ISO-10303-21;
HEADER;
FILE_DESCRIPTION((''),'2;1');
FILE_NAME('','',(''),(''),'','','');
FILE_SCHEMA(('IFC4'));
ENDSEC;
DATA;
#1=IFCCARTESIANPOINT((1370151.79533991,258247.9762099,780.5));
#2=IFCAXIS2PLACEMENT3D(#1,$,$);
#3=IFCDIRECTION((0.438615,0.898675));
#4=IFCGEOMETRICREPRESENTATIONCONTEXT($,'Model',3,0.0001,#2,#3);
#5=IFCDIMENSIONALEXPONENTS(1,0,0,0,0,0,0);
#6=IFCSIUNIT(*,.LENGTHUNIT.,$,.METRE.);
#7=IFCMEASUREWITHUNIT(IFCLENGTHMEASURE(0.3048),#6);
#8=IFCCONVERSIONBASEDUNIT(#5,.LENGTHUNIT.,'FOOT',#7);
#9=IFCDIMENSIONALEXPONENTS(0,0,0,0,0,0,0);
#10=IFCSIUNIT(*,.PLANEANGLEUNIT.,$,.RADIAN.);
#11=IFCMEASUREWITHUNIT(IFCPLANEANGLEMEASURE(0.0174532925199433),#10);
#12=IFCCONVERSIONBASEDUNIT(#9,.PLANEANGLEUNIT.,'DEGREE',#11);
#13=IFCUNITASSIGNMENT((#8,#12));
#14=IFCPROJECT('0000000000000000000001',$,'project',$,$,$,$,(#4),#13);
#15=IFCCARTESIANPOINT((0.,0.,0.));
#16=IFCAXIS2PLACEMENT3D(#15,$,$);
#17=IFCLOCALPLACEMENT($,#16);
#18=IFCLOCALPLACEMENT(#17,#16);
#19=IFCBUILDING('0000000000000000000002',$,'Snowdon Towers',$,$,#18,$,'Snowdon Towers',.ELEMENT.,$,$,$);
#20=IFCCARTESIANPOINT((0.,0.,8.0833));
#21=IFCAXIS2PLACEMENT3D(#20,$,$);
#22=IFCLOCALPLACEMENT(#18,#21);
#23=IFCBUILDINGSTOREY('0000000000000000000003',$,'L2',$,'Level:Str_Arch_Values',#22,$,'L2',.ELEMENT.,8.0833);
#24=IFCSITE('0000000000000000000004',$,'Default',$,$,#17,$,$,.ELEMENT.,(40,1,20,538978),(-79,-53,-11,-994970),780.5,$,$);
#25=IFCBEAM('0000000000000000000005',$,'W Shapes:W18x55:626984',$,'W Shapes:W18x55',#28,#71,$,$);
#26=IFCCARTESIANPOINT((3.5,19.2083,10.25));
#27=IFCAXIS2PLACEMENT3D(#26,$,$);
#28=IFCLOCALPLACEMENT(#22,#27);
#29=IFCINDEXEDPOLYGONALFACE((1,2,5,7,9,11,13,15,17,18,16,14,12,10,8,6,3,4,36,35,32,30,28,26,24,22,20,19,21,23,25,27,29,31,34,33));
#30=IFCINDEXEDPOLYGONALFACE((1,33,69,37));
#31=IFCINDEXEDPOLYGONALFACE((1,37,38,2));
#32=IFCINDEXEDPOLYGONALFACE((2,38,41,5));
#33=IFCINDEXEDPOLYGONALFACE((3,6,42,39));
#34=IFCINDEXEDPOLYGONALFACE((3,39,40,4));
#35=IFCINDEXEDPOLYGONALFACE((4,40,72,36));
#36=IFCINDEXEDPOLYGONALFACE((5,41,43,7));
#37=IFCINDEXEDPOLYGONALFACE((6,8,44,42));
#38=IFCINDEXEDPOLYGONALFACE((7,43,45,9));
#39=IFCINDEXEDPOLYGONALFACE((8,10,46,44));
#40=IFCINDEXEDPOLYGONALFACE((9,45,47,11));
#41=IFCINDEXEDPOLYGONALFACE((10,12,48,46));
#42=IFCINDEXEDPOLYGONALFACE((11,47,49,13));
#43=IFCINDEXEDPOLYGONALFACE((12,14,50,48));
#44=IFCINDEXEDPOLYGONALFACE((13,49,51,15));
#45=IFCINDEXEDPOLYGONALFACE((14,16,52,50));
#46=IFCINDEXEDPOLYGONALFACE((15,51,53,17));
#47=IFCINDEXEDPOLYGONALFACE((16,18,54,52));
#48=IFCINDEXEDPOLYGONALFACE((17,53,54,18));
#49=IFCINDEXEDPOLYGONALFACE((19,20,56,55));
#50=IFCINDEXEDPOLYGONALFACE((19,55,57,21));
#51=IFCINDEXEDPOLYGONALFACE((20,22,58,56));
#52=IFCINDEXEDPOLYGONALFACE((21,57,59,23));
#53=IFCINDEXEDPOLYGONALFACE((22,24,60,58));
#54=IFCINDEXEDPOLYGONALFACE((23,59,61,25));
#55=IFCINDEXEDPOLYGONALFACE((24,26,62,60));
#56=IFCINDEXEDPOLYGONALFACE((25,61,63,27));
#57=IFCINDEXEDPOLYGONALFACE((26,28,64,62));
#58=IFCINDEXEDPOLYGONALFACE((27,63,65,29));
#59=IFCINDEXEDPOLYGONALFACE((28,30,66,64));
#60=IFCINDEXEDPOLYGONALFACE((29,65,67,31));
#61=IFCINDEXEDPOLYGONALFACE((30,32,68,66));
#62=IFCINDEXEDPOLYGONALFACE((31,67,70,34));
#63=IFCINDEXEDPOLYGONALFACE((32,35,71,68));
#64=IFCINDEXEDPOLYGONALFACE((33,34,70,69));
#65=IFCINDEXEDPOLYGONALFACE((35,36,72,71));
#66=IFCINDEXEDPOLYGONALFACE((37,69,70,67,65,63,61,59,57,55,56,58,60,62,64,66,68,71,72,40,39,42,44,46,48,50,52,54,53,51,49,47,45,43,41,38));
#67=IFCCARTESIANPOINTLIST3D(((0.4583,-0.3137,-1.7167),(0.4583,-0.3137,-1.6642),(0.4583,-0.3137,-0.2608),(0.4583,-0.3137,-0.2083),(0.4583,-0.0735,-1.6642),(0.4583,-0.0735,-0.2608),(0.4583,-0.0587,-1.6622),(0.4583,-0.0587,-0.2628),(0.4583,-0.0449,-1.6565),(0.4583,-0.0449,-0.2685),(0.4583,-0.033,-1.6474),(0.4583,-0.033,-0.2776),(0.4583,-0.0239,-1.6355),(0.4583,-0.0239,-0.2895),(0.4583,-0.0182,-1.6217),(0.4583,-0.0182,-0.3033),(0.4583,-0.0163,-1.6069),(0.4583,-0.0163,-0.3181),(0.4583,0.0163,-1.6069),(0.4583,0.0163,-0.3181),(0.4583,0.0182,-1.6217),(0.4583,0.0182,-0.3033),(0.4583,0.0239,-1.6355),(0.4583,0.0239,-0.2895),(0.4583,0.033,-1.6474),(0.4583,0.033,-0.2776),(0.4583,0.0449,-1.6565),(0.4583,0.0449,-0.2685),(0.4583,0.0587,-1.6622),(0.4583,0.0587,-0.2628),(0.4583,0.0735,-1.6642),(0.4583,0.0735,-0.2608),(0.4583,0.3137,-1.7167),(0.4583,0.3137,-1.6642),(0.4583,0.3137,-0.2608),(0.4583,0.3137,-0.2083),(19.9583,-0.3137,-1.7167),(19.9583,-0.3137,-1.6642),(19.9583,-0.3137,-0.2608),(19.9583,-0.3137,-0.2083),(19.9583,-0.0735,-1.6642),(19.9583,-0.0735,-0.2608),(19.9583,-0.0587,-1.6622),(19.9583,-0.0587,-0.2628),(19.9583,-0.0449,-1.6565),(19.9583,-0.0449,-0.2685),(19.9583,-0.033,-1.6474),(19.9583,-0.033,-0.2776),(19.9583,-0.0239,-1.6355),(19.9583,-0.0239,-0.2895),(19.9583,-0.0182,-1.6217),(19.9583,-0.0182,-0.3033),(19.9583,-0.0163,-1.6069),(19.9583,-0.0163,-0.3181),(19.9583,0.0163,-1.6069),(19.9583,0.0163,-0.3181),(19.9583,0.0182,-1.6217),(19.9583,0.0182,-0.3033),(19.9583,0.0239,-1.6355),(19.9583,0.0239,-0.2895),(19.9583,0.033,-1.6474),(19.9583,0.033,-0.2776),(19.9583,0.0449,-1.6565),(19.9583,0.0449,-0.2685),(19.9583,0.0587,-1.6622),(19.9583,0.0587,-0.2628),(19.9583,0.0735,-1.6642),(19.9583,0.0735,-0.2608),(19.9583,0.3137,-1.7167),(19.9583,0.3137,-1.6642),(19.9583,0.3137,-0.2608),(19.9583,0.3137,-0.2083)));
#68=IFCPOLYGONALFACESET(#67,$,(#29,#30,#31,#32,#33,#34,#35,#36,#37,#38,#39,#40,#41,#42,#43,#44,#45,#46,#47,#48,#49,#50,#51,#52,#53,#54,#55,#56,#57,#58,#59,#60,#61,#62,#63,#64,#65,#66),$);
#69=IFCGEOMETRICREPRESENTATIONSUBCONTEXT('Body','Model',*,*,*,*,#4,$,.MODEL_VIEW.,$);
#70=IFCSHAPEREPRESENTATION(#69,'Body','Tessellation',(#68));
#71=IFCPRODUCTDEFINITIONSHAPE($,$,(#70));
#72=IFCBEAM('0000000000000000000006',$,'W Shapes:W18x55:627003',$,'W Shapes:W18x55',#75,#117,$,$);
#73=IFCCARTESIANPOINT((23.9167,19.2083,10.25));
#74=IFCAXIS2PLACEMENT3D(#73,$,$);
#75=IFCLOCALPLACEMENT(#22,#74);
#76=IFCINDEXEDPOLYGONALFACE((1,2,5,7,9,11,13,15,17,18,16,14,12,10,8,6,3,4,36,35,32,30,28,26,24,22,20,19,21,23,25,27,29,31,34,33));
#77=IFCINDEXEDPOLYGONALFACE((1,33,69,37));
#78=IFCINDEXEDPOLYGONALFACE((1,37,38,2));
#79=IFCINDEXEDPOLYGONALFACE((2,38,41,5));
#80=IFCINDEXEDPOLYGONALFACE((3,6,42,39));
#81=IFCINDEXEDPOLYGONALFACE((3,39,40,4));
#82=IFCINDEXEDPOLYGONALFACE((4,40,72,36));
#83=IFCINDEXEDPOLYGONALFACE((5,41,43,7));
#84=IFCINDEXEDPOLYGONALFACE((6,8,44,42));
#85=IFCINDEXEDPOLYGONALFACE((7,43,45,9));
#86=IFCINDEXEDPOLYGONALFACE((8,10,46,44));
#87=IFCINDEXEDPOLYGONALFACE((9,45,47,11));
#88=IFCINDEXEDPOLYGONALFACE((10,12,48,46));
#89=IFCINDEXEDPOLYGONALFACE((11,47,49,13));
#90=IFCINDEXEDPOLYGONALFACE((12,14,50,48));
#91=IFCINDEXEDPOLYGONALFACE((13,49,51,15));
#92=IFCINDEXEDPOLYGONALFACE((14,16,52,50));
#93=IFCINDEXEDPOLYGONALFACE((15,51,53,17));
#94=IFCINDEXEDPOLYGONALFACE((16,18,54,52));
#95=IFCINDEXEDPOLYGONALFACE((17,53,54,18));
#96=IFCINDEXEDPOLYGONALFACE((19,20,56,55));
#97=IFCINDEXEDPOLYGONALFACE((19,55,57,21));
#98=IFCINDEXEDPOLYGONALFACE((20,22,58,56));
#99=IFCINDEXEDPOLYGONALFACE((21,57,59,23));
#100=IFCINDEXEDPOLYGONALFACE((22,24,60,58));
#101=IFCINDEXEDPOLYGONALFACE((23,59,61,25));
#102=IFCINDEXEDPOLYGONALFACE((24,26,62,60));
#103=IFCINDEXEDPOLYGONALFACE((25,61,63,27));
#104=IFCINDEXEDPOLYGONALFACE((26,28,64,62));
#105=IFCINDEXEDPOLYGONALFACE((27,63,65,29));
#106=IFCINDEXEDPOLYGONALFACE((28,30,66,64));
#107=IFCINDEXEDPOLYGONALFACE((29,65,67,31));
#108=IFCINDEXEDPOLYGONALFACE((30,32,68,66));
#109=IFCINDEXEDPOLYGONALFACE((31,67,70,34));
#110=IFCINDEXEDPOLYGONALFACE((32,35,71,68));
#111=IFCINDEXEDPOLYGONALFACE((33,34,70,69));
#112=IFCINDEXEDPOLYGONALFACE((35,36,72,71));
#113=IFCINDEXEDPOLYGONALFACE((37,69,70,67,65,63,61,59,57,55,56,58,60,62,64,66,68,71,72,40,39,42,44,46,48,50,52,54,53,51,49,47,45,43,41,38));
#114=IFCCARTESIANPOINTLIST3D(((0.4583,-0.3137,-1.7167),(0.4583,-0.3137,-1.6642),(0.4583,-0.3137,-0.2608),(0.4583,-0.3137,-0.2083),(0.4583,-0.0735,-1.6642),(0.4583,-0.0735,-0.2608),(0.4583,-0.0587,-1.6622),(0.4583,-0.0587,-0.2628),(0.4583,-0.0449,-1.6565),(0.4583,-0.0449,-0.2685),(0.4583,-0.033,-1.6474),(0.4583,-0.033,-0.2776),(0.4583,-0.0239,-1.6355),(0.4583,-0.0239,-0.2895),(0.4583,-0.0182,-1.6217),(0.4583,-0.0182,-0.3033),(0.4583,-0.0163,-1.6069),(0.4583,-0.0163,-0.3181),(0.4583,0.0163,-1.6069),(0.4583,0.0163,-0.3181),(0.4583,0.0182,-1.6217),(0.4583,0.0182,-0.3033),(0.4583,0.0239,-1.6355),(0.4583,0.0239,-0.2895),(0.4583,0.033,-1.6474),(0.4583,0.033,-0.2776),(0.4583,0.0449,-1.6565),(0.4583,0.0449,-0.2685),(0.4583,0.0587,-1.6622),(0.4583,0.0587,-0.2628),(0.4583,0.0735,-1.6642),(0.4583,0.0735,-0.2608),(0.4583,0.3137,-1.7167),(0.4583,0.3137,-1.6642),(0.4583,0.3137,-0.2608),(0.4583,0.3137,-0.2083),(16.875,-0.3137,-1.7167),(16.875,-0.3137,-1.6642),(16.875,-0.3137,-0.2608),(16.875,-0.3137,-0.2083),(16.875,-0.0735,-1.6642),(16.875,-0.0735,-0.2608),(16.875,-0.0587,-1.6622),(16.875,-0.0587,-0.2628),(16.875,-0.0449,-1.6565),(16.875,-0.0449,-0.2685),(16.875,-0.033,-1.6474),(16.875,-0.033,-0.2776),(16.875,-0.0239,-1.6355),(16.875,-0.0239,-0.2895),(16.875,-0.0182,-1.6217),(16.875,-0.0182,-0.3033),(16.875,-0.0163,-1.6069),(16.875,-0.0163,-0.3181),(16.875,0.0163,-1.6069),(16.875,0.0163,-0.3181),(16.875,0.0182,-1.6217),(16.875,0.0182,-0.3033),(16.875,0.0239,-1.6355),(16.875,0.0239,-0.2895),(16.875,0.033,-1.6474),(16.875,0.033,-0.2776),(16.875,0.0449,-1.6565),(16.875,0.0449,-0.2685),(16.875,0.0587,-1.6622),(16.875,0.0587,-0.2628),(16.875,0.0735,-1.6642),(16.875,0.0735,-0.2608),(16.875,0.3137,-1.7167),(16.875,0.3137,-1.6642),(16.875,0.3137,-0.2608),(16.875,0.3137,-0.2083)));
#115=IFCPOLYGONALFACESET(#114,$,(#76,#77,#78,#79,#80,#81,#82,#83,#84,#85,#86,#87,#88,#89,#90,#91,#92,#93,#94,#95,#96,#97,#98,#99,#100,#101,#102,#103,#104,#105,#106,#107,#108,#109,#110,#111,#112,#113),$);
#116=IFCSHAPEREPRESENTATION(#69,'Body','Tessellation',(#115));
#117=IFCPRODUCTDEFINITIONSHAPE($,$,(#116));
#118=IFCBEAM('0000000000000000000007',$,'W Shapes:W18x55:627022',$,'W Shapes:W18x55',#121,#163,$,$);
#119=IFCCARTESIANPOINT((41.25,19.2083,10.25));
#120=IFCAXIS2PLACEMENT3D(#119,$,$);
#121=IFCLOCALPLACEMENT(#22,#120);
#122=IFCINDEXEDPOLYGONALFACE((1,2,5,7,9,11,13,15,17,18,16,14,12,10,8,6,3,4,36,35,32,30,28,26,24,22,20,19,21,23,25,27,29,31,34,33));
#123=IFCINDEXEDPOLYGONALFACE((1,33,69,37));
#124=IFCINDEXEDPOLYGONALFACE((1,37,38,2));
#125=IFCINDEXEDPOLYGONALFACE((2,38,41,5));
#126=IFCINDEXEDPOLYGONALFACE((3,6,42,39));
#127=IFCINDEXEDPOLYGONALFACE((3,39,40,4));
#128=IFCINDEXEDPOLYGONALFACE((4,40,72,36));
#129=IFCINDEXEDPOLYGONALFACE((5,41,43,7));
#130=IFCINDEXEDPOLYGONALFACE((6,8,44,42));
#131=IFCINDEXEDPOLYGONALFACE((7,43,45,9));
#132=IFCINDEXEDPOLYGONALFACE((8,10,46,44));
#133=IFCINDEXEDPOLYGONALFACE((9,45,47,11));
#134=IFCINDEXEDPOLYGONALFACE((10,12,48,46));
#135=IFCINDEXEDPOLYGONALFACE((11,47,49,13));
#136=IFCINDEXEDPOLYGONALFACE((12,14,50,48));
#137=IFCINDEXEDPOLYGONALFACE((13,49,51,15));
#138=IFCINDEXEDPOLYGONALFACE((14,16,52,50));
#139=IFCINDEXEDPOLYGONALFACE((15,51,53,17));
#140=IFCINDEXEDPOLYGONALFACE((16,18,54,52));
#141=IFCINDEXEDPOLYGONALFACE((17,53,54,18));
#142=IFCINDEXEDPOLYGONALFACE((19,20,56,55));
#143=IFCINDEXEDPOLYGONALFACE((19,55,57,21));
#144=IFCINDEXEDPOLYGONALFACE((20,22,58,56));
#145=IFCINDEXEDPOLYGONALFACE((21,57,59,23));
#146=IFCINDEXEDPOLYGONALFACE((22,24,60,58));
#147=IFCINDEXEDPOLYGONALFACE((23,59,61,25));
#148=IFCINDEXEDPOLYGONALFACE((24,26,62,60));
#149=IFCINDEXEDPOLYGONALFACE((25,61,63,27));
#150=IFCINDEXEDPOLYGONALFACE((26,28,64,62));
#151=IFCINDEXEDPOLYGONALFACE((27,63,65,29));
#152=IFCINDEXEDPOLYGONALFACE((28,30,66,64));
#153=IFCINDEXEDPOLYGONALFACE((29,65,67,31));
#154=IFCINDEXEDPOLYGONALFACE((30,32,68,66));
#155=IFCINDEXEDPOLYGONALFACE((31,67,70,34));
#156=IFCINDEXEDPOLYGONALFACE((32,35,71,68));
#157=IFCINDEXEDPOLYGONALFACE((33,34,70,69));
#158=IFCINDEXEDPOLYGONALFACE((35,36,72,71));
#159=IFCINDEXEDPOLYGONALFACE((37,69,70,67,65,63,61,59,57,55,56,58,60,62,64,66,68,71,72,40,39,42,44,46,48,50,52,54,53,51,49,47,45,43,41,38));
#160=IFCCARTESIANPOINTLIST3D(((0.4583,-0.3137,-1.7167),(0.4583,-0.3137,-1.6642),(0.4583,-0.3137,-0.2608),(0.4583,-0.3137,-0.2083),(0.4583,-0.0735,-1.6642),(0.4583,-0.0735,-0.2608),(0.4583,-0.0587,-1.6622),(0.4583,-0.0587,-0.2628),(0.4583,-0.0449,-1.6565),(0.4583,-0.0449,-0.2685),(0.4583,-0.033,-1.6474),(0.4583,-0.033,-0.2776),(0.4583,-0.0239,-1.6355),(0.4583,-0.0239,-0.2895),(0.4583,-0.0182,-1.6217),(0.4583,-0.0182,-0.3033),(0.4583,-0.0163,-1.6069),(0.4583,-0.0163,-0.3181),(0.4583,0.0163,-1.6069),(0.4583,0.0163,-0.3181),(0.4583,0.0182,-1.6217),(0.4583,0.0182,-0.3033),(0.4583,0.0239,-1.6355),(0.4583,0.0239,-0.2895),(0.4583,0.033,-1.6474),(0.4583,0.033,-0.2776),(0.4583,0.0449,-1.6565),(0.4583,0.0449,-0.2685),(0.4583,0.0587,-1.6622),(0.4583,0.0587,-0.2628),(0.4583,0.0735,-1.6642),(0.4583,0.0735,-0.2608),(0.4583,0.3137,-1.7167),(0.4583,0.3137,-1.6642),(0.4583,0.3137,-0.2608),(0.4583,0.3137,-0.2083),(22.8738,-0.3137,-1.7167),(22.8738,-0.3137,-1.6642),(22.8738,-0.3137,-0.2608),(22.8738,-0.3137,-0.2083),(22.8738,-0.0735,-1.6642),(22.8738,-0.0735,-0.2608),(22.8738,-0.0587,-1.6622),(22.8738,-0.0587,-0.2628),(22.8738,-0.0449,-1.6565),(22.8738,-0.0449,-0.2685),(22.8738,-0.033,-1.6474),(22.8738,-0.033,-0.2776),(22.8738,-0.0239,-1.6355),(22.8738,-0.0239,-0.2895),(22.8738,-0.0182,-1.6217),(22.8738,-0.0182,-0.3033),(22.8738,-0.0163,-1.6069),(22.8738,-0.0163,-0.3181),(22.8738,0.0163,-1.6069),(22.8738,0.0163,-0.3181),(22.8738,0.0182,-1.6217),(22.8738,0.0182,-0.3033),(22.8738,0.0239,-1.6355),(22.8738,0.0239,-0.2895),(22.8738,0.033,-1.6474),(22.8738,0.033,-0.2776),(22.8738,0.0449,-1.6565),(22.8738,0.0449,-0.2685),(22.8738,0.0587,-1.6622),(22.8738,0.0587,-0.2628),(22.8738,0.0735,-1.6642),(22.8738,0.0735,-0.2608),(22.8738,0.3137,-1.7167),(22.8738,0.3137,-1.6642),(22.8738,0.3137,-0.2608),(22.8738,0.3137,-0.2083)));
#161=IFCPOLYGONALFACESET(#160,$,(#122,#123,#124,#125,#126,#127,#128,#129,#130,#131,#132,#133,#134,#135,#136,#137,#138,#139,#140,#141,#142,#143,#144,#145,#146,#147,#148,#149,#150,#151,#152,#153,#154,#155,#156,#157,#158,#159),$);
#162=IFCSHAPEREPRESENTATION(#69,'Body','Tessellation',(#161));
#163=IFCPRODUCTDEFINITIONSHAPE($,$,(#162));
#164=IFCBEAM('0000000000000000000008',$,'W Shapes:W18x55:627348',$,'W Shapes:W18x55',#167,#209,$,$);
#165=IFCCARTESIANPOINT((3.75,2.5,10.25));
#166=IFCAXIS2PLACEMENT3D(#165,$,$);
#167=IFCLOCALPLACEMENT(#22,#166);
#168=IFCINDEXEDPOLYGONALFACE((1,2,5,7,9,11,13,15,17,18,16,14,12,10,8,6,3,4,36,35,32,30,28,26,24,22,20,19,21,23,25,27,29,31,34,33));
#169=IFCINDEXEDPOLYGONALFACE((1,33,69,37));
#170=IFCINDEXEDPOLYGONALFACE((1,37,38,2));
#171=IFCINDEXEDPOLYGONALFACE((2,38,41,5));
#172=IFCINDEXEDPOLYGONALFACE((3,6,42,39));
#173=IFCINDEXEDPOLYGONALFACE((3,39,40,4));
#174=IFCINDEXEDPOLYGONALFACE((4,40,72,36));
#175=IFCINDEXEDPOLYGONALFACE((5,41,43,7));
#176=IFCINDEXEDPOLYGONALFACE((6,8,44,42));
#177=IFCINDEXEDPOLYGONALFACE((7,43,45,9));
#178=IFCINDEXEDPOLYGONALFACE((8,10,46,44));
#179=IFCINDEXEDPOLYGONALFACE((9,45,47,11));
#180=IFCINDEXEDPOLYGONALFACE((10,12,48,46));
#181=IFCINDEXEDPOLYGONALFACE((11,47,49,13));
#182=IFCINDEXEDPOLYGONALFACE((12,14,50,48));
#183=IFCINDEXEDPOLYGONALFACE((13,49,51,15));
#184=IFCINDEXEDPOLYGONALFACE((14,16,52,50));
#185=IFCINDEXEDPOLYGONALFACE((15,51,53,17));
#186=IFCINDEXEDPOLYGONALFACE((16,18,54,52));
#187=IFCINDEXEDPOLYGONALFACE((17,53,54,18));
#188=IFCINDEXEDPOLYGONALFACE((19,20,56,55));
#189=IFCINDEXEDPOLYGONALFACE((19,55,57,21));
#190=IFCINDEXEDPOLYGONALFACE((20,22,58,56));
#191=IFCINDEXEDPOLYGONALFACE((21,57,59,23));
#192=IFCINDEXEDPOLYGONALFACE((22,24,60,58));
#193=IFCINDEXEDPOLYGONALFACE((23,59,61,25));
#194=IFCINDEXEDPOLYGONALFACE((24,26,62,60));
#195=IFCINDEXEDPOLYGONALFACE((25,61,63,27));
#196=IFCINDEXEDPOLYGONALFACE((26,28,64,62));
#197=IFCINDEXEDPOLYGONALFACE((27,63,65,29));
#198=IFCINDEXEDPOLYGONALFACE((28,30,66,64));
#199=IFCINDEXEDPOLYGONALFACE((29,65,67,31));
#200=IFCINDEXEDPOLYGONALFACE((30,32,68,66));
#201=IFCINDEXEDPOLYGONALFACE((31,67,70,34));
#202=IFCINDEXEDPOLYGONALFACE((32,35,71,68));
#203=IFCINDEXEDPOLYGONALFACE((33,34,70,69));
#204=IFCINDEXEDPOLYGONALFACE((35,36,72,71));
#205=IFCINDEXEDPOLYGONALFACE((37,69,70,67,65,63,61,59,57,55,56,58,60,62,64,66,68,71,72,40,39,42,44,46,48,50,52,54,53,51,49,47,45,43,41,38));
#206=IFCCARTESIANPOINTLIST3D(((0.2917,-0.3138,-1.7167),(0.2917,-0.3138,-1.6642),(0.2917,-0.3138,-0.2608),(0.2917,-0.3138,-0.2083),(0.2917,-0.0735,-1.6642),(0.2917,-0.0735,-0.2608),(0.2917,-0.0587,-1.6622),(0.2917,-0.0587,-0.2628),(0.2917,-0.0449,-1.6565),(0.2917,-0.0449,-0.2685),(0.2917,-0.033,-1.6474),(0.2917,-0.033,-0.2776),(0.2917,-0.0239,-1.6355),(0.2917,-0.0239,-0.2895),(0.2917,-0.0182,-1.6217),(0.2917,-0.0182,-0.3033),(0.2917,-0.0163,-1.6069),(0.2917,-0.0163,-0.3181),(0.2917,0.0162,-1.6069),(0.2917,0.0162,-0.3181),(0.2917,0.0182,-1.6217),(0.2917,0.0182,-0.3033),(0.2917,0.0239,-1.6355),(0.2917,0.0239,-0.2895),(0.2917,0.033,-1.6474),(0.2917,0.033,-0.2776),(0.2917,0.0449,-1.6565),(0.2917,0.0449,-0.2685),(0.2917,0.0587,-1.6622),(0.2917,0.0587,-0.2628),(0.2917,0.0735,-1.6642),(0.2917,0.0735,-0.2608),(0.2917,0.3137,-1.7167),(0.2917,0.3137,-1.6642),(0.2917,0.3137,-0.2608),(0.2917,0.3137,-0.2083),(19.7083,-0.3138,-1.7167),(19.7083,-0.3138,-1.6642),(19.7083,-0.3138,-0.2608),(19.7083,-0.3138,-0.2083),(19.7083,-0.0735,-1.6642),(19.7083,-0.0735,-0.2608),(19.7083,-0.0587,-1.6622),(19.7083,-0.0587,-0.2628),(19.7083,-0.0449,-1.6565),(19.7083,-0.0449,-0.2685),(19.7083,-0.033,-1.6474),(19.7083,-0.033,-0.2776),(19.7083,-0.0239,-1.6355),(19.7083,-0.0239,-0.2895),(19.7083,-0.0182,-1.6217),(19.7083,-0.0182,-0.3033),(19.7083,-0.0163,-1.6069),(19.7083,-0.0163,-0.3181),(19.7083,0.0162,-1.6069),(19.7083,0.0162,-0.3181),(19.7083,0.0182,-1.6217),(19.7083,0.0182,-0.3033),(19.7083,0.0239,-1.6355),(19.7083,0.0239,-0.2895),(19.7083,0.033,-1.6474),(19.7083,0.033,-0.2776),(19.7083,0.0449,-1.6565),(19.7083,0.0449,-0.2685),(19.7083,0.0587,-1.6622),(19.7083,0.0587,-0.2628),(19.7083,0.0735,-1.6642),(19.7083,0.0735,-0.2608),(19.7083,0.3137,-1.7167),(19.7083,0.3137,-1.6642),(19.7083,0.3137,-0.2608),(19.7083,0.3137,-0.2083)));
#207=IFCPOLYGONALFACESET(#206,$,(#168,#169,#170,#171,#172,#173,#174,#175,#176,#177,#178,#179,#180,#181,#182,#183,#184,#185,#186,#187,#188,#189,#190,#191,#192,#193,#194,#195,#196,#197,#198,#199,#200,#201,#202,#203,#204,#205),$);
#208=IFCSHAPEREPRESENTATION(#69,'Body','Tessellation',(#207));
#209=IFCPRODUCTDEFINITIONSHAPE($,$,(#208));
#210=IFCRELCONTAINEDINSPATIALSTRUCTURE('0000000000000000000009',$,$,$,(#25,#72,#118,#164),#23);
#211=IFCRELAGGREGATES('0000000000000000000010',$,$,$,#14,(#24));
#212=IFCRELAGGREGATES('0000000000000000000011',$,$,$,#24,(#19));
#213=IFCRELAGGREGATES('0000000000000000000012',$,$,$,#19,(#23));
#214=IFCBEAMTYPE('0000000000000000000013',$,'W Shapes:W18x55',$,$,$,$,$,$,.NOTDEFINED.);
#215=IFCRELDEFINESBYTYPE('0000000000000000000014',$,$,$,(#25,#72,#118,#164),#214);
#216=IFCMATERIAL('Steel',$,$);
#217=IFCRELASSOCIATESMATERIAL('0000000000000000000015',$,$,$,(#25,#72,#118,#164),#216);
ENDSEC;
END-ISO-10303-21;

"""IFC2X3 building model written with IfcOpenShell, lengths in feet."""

from ifc_helpers import new_model, entity, si_unit, converted_unit, direction, frame, frame_2d, origin, place, context, subcontext, project, spatial, i_section, extrude, material, type_object, element, save


model = new_model("IFC2X3")

# Units and contexts
model_context = context("Model", 3, precision=0.0001, world=frame((1370151.79533991, 258247.9762099, 780.5)), true_north=direction((0.438615, 0.898675)))
body_context = subcontext(model_context, "Body", "Model", "MODEL_VIEW")
ifc_project = project(units=[converted_unit("LENGTHUNIT", "FOOT", entity("IfcLengthMeasure", 0.3048), si_unit("LENGTHUNIT", "METRE"), dimensions=[1, 0, 0, 0, 0, 0, 0]), converted_unit("PLANEANGLEUNIT", "DEGREE", entity("IfcPlaneAngleMeasure", 0.0174532925199433), si_unit("PLANEANGLEUNIT", "RADIAN"), dimensions=[0, 0, 0, 0, 0, 0, 0])], contexts=[model_context])

# Site, building, storey
site_placement = place(None, origin())
site = spatial("IfcSite", under=ifc_project, at=site_placement, Name="Default", CompositionType="ELEMENT", RefLatitude=(40, 1, 20, 538978), RefLongitude=(-79, -53, -11, -994970), RefElevation=780.5)
building_placement = place(site_placement, origin())
building = spatial("IfcBuilding", under=site, at=building_placement, Name="Snowdon Towers", LongName="Snowdon Towers", CompositionType="ELEMENT")
storey_placement = place(building_placement, frame((0.0, 0.0, 8.0833)))
storey = spatial("IfcBuildingStorey", under=building, at=storey_placement, Name="L2", ObjectType="Level:Str_Arch_Values", LongName="L2", CompositionType="ELEMENT", Elevation=8.0833)

# Beams
ifc_material = material(Name="Steel")
beam_type_1 = type_object("IfcBeamType", Name="W Shapes:W18x55", PredefinedType="NOTDEFINED")
beam_1_placement = place(storey_placement, frame((3.5, 19.2083, 10.25)))
element("IfcBeam", 1, at=beam_1_placement, inside=storey, type_object=beam_type_1, material=ifc_material, Name="W Shapes:W18x55:626984", ObjectType="W Shapes:W18x55", context=body_context, shape_type="SweptSolid", body=[
    extrude(i_section(OverallWidth=0.6275, OverallDepth=1.5083, WebThickness=0.0325, FlangeThickness=0.0525, FilletRadius=0.0573, at=frame_2d((0.0, 0.0), x_axis=(0.0, 1.0))), frame((0.4583, 0.0, -0.9625), z_axis=(1.0, 0.0, 0.0), x_axis=(0.0, 0.0, -1.0)), (0.0, 0.0, 1.0), 19.5),
])
beam_2_placement = place(storey_placement, frame((23.9167, 19.2083, 10.25)))
element("IfcBeam", 2, at=beam_2_placement, inside=storey, type_object=beam_type_1, material=ifc_material, Name="W Shapes:W18x55:627003", ObjectType="W Shapes:W18x55", context=body_context, shape_type="SweptSolid", body=[
    extrude(i_section(OverallWidth=0.6275, OverallDepth=1.5083, WebThickness=0.0325, FlangeThickness=0.0525, FilletRadius=0.0573, at=frame_2d((0.0, 0.0), x_axis=(0.0, 1.0))), frame((0.4583, 0.0, -0.9625), z_axis=(1.0, 0.0, 0.0), x_axis=(0.0, 0.0, -1.0)), (0.0, 0.0, 1.0), 16.4167),
])
beam_3_placement = place(storey_placement, frame((41.25, 19.2083, 10.25)))
element("IfcBeam", 3, at=beam_3_placement, inside=storey, type_object=beam_type_1, material=ifc_material, Name="W Shapes:W18x55:627022", ObjectType="W Shapes:W18x55", context=body_context, shape_type="SweptSolid", body=[
    extrude(i_section(OverallWidth=0.6275, OverallDepth=1.5083, WebThickness=0.0325, FlangeThickness=0.0525, FilletRadius=0.0573, at=frame_2d((0.0, 0.0), x_axis=(0.0, 1.0))), frame((0.4583, 0.0, -0.9625), z_axis=(1.0, 0.0, 0.0), x_axis=(0.0, 0.0, -1.0)), (0.0, 0.0, 1.0), 22.4154),
])
beam_4_placement = place(storey_placement, frame((3.75, 2.5, 10.25)))
element("IfcBeam", 4, at=beam_4_placement, inside=storey, type_object=beam_type_1, material=ifc_material, Name="W Shapes:W18x55:627348", ObjectType="W Shapes:W18x55", context=body_context, shape_type="SweptSolid", body=[
    extrude(i_section(OverallWidth=0.6275, OverallDepth=1.5083, WebThickness=0.0325, FlangeThickness=0.0525, FilletRadius=0.0573, at=frame_2d((0.0, 0.0), x_axis=(0.0, 1.0))), frame((0.2917, 0.0, -0.9625), z_axis=(1.0, 0.0, 0.0), x_axis=(0.0, 0.0, -1.0)), (0.0, 0.0, 1.0), 19.4167),
])

save(model, "model.ifc")
